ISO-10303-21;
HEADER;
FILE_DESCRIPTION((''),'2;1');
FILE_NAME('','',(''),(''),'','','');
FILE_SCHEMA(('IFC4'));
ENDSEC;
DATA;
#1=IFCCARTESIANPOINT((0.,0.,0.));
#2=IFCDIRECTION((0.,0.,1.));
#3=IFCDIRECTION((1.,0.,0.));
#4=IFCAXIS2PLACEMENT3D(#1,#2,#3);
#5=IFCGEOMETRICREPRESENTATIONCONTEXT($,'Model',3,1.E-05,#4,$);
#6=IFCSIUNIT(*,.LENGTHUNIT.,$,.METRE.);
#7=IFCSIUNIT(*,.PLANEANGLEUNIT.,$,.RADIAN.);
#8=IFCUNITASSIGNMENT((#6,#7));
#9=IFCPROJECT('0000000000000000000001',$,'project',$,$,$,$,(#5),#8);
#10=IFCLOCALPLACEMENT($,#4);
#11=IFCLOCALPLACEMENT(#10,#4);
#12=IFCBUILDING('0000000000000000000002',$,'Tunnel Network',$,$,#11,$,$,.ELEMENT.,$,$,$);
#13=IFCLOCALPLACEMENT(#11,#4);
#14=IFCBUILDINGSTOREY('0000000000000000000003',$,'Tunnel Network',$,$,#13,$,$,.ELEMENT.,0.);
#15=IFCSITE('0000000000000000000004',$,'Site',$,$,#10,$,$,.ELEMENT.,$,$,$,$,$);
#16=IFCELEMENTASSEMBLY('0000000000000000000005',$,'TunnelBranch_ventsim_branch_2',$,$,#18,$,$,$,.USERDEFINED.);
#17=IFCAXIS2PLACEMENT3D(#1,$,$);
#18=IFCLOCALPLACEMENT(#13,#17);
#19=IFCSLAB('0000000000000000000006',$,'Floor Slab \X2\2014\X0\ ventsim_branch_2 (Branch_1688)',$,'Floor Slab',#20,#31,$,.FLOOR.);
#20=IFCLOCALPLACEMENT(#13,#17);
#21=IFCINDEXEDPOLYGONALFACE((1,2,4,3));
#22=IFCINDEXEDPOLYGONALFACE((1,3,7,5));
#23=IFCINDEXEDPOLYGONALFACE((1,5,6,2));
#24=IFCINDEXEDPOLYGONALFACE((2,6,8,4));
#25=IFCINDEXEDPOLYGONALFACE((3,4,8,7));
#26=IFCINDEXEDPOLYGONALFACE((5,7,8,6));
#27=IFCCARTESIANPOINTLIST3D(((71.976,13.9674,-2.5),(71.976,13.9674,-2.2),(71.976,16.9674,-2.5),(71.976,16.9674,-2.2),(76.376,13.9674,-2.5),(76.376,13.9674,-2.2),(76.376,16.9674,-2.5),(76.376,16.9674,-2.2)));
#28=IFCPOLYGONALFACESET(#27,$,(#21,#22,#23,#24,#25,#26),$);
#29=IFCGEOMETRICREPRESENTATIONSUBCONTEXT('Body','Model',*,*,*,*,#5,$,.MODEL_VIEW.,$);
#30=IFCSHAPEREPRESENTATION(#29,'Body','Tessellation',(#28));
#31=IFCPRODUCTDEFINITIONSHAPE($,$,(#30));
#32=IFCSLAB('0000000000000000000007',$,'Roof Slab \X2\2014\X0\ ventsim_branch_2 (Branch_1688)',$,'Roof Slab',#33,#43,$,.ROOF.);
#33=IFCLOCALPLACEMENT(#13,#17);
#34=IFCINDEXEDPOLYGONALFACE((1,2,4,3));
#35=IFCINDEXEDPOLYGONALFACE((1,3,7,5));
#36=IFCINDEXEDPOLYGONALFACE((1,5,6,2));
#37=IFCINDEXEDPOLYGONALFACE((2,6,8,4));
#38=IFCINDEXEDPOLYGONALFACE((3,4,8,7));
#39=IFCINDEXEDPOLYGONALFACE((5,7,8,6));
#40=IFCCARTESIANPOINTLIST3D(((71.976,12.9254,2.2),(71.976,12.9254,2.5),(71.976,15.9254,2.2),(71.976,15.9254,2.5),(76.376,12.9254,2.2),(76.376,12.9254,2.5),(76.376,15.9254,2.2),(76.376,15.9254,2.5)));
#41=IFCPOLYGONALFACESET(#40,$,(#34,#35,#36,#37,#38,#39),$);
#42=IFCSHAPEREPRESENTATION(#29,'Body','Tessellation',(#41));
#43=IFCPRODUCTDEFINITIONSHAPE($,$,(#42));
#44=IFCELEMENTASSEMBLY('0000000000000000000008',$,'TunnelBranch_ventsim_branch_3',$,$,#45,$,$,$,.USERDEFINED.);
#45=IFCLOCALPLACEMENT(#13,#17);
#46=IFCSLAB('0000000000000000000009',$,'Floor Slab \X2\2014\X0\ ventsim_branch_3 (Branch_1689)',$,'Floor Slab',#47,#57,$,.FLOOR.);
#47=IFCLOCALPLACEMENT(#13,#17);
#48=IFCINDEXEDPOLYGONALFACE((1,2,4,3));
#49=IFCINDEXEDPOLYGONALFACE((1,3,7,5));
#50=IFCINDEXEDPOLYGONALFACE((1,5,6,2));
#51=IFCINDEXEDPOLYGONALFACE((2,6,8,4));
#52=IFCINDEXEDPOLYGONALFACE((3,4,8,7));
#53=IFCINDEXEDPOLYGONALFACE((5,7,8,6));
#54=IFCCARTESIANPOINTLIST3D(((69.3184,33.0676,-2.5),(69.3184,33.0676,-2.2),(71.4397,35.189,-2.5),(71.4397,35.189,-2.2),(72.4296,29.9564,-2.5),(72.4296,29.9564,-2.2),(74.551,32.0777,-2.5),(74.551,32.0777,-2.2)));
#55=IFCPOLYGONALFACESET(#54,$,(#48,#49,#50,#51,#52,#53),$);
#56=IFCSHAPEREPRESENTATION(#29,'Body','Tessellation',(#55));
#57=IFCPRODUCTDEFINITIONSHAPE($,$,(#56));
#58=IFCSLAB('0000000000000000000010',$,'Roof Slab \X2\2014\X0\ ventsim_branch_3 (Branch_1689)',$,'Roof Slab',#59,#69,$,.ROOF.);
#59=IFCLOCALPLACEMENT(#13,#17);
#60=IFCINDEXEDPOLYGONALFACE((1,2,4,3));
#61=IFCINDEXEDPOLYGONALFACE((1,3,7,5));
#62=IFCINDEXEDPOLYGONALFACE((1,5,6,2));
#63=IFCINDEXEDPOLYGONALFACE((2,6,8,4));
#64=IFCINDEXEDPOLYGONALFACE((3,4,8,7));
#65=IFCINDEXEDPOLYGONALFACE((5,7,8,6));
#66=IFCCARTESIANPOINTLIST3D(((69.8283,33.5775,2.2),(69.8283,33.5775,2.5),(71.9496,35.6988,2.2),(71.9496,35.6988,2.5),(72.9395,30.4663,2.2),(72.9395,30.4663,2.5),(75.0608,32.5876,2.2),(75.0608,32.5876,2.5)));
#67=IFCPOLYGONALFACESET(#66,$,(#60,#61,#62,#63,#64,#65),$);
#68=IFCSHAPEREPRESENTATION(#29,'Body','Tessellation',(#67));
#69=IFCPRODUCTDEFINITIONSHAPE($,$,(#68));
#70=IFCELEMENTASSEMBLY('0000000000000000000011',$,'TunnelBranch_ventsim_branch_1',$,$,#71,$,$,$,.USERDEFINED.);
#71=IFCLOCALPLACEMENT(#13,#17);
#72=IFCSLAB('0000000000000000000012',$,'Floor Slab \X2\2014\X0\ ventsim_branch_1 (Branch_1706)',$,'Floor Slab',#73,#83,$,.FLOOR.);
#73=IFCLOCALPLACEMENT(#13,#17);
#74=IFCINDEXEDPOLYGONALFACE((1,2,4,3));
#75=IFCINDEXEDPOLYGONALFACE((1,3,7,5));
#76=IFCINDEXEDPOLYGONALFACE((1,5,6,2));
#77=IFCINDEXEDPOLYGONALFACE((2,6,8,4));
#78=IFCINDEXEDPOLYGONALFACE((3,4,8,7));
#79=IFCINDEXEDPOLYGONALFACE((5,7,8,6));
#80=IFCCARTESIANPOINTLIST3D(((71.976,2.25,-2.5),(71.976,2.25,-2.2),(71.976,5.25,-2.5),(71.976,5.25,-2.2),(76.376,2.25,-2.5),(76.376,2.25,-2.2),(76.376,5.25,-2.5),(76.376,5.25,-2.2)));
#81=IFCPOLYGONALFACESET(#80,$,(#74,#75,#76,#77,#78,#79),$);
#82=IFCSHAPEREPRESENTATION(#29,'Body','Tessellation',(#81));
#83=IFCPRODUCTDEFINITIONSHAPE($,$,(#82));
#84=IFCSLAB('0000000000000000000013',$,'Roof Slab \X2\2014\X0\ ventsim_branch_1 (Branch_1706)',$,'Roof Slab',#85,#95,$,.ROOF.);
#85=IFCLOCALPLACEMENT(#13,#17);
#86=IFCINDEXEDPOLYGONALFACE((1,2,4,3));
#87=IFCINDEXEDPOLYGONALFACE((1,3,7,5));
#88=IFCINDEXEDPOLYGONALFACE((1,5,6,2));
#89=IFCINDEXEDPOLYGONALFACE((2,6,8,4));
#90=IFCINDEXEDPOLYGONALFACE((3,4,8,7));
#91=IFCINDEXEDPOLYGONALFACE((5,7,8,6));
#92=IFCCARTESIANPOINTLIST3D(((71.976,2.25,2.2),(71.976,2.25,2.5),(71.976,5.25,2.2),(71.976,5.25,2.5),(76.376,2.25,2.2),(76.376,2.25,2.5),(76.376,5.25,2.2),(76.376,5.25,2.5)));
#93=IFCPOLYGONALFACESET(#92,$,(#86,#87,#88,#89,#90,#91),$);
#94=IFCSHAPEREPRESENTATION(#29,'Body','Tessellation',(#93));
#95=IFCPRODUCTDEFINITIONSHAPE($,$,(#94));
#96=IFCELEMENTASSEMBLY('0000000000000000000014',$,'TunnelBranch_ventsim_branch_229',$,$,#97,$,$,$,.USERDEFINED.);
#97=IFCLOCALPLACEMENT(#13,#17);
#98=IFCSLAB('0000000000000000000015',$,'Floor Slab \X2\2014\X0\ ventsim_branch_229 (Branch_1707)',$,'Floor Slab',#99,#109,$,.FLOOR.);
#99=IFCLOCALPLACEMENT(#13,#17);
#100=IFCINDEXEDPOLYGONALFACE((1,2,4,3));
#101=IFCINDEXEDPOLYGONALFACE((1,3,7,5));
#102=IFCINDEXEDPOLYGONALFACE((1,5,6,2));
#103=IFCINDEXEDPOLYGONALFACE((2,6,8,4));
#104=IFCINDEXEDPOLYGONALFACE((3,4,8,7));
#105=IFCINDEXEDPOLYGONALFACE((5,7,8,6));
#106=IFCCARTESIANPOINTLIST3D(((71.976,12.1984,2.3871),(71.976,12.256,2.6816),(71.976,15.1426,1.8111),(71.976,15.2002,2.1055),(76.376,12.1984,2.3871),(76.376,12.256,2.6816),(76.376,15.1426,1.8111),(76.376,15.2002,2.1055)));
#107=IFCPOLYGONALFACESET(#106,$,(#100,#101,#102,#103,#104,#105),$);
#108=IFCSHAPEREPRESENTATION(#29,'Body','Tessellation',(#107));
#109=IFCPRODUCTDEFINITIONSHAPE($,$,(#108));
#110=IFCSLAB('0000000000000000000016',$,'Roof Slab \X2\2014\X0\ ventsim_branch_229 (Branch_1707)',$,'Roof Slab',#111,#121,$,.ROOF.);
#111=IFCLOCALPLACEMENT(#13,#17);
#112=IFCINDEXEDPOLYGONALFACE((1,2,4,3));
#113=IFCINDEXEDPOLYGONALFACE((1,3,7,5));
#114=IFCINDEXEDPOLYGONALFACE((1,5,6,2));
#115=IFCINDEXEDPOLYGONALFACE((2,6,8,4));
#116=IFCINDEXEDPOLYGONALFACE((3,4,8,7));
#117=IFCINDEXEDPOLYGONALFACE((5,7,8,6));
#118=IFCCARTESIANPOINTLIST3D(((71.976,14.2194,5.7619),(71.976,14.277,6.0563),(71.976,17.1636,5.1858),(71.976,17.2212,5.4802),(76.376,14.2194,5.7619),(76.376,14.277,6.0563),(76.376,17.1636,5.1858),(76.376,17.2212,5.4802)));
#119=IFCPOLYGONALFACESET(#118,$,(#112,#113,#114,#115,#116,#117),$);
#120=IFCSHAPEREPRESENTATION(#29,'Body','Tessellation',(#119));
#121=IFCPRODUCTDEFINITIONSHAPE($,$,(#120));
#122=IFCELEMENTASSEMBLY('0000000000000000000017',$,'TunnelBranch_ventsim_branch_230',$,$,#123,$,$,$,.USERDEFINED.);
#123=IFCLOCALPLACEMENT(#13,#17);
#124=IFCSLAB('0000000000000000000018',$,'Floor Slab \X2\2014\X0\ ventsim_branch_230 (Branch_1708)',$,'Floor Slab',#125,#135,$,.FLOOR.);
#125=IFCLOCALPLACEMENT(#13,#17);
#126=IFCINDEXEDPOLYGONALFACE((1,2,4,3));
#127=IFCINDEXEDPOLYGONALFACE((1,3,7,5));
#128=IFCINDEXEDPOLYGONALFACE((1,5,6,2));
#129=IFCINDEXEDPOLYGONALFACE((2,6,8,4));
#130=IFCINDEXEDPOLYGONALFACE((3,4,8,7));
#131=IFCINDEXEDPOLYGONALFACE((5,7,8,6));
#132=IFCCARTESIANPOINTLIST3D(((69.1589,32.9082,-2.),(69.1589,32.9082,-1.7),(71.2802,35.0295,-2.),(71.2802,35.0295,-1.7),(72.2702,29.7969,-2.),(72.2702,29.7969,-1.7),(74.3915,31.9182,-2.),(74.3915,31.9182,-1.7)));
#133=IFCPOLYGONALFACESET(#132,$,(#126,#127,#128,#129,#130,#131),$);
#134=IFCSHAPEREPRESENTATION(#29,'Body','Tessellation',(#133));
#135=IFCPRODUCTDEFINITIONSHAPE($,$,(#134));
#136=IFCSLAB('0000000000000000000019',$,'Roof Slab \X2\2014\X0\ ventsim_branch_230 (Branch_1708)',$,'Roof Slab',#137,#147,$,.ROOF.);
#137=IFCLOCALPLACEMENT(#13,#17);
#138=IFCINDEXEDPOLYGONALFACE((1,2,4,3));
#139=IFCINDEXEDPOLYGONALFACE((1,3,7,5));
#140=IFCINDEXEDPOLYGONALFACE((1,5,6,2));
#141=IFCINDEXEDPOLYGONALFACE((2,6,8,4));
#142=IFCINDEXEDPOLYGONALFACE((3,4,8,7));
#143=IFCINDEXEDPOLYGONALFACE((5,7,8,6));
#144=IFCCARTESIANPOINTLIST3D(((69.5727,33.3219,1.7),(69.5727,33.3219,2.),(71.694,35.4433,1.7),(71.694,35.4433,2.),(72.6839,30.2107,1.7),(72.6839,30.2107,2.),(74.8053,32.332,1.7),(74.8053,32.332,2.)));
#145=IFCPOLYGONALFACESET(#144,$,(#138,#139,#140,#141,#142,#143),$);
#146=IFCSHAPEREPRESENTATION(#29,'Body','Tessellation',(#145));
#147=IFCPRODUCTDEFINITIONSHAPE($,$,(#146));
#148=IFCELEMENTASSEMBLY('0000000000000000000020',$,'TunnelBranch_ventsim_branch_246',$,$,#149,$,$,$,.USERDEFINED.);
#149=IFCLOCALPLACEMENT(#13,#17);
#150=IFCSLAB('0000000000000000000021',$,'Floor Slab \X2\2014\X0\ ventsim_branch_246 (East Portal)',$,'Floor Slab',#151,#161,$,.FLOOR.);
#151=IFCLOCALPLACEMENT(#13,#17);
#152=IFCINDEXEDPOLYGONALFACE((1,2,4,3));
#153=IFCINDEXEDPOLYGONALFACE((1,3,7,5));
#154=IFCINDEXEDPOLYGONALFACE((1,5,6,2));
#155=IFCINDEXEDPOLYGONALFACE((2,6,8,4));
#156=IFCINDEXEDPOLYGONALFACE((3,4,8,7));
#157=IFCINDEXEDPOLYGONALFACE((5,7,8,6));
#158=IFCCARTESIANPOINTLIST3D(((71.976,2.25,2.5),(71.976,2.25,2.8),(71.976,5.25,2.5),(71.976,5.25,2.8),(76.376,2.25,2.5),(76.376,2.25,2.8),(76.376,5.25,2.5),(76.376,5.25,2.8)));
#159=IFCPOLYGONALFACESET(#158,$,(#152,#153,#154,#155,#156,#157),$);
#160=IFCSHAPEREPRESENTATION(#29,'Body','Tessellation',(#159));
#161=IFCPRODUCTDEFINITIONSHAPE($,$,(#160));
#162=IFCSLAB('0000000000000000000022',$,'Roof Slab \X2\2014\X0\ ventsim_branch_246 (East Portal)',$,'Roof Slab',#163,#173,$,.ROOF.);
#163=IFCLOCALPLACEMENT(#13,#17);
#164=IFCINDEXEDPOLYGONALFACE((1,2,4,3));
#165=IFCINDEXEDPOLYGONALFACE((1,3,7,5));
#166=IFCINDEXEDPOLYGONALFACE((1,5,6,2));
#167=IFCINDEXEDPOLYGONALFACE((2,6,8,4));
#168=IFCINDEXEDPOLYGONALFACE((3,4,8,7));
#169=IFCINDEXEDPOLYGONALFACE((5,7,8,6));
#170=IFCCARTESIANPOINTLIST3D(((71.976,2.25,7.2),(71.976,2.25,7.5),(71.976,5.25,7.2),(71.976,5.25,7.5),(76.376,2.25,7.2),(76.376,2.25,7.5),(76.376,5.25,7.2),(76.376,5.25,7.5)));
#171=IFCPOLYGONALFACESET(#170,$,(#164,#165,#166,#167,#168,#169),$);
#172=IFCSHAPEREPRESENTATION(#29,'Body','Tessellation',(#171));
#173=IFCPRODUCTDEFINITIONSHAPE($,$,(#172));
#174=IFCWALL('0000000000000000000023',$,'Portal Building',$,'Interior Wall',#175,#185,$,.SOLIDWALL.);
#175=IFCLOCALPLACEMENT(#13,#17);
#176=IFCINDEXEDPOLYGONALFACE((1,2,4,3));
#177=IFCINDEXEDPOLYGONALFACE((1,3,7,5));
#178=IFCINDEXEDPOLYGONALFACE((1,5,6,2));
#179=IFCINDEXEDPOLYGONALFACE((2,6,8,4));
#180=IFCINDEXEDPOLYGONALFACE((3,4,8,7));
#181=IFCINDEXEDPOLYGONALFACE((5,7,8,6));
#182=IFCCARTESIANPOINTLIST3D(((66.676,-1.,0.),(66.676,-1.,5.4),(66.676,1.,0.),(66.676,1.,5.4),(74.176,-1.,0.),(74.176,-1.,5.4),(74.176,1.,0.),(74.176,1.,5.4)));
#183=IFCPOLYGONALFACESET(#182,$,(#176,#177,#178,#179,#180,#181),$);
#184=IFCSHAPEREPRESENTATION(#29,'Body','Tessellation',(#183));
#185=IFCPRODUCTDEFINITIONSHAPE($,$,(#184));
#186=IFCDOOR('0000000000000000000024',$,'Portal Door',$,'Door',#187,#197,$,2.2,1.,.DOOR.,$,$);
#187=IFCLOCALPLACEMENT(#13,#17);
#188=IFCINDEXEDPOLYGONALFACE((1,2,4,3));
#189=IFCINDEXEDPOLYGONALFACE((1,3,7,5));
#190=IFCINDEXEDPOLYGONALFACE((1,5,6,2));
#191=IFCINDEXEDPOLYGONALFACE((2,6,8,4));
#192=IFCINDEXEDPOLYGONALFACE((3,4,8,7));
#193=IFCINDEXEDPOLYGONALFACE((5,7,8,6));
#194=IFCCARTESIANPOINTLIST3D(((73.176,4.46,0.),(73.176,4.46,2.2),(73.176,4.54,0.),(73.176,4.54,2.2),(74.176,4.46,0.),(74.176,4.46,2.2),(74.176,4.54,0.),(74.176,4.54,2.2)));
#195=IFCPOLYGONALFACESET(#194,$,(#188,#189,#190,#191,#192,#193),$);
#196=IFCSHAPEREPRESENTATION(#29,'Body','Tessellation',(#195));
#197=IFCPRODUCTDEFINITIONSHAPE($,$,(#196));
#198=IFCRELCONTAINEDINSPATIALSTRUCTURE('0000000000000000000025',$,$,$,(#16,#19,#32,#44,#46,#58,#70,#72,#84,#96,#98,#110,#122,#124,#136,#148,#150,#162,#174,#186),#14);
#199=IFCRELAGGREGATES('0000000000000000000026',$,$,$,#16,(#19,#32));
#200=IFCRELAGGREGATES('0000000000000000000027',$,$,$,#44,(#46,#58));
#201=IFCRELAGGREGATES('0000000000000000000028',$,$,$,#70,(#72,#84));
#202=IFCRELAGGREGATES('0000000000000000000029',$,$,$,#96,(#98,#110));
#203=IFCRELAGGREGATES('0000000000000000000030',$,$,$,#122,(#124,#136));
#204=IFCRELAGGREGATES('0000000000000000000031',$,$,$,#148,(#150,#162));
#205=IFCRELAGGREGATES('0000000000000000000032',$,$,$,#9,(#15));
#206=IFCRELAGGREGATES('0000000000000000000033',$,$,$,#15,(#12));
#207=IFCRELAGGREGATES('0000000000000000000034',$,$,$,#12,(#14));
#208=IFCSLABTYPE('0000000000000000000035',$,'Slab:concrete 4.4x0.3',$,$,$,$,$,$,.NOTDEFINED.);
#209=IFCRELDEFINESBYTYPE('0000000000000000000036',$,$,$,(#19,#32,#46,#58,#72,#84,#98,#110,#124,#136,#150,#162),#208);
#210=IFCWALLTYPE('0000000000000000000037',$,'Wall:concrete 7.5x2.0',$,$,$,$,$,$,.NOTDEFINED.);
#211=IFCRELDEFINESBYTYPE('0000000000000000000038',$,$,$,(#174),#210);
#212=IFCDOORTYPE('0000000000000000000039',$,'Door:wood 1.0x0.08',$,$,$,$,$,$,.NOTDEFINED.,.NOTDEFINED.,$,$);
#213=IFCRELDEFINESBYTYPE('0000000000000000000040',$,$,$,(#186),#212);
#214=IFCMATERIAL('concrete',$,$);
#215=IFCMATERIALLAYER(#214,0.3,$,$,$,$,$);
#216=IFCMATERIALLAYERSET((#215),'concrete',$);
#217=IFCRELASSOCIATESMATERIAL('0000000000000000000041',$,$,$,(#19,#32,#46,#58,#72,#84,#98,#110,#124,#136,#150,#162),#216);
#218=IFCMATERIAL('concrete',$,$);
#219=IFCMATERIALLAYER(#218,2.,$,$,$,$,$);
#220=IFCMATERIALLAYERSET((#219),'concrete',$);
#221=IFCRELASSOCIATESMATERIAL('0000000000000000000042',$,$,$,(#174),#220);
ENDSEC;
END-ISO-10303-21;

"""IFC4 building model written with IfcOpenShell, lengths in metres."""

from ifc_helpers import new_model, si_unit, frame, origin_with_axes, origin_2d_with_axis, place, context, subcontext, project, spatial, rectangle, extrude, material, layer, layer_set, layer_usage, type_object, element, aggregate, save


model = new_model("IFC4")

# Units and contexts
model_context = context("Model", 3, precision=1e-05, world=origin_with_axes())
body_context = subcontext(model_context, "Body", "Model", "MODEL_VIEW")
ifc_project = project(units=[si_unit("LENGTHUNIT", "METRE"), si_unit("PLANEANGLEUNIT", "RADIAN")], contexts=[model_context])

# Site, building, storey
site_placement = place(None, origin_with_axes())
site = spatial("IfcSite", under=ifc_project, at=site_placement, Name="Site", CompositionType="ELEMENT")
building_placement = place(site_placement, origin_with_axes())
building = spatial("IfcBuilding", under=site, at=building_placement, Name="Tunnel Network", CompositionType="ELEMENT")
storey_placement = place(building_placement, origin_with_axes())
storey = spatial("IfcBuildingStorey", under=building, at=storey_placement, Name="Tunnel Network", CompositionType="ELEMENT", Elevation=0.0)

# Element assemblies, slabs
assembly_1_placement = place(storey_placement, frame((71.826, 11.0879, 0.0), z_axis=(0.0, 1.0, 0.0), x_axis=(1.0, 0.0, 0.0)))
assembly_1 = element("IfcElementAssembly", 1, at=assembly_1_placement, inside=storey, Name="TunnelBranch_ventsim_branch_2", PredefinedType="USERDEFINED")
ifc_material_1 = material(Name="concrete")
ifc_layer_1 = layer(ifc_material_1, 0.3)
ifc_layer_set_1 = layer_set([ifc_layer_1], Name="concrete")
ifc_layer_usage_1 = layer_usage(ifc_layer_set_1, "AXIS3", "POSITIVE", 0.0)
slab_type = type_object("IfcSlabType", Name="Slab:concrete 4.4x0.3")
slab_1_placement = place(storey_placement, frame((74.176, 13.9674, -2.35), z_axis=(0.0, 1.0, 0.0), x_axis=(1.0, 0.0, 0.0)))
slab_1 = element("IfcSlab", 2, at=slab_1_placement, inside=storey, type_object=slab_type, material=ifc_layer_usage_1, Name="Floor Slab — ventsim_branch_2 (Branch_1688)", ObjectType="Floor Slab", PredefinedType="FLOOR", context=body_context, shape_type="SweptSolid", body=[
    extrude(rectangle(XDim=4.4, YDim=0.3, at=origin_2d_with_axis()), origin_with_axes(), (0.0, 0.0, 1.0), 3.0),
])
ifc_layer_usage_2 = layer_usage(ifc_layer_set_1, "AXIS3", "POSITIVE", 0.0)
slab_2_placement = place(storey_placement, frame((74.176, 12.9254, 2.35), z_axis=(0.0, 1.0, 0.0), x_axis=(1.0, 0.0, 0.0)))
slab_2 = element("IfcSlab", 3, at=slab_2_placement, inside=storey, type_object=slab_type, material=ifc_layer_usage_2, Name="Roof Slab — ventsim_branch_2 (Branch_1688)", ObjectType="Roof Slab", PredefinedType="ROOF", context=body_context, shape_type="SweptSolid", body=[
    extrude(rectangle(XDim=4.4, YDim=0.3, at=origin_2d_with_axis()), origin_with_axes(), (0.0, 0.0, 1.0), 3.0),
])
assembly_2_placement = place(storey_placement, frame((68.165, 32.1264, 0.0), z_axis=(0.707107, 0.707107, 0.0), x_axis=(0.707107, -0.707107, 0.0)))
assembly_2 = element("IfcElementAssembly", 4, at=assembly_2_placement, inside=storey, Name="TunnelBranch_ventsim_branch_3", PredefinedType="USERDEFINED")
ifc_layer_usage_3 = layer_usage(ifc_layer_set_1, "AXIS3", "POSITIVE", 0.0)
slab_3_placement = place(storey_placement, frame((70.874, 31.512, -2.35), z_axis=(0.707107, 0.707107, 0.0), x_axis=(0.707107, -0.707107, 0.0)))
slab_3 = element("IfcSlab", 5, at=slab_3_placement, inside=storey, type_object=slab_type, material=ifc_layer_usage_3, Name="Floor Slab — ventsim_branch_3 (Branch_1689)", ObjectType="Floor Slab", PredefinedType="FLOOR", context=body_context, shape_type="SweptSolid", body=[
    extrude(rectangle(XDim=4.4, YDim=0.3, at=origin_2d_with_axis()), origin_with_axes(), (0.0, 0.0, 1.0), 3.0),
])
ifc_layer_usage_4 = layer_usage(ifc_layer_set_1, "AXIS3", "POSITIVE", 0.0)
slab_4_placement = place(storey_placement, frame((71.3839, 32.0219, 2.35), z_axis=(0.707107, 0.707107, 0.0), x_axis=(0.707107, -0.707107, 0.0)))
slab_4 = element("IfcSlab", 6, at=slab_4_placement, inside=storey, type_object=slab_type, material=ifc_layer_usage_4, Name="Roof Slab — ventsim_branch_3 (Branch_1689)", ObjectType="Roof Slab", PredefinedType="ROOF", context=body_context, shape_type="SweptSolid", body=[
    extrude(rectangle(XDim=4.4, YDim=0.3, at=origin_2d_with_axis()), origin_with_axes(), (0.0, 0.0, 1.0), 3.0),
])
assembly_3_placement = place(storey_placement, frame((71.826, 2.25, 0.0), z_axis=(0.0, 1.0, 0.0), x_axis=(1.0, 0.0, 0.0)))
assembly_3 = element("IfcElementAssembly", 7, at=assembly_3_placement, inside=storey, Name="TunnelBranch_ventsim_branch_1", PredefinedType="USERDEFINED")
ifc_layer_usage_5 = layer_usage(ifc_layer_set_1, "AXIS3", "POSITIVE", 0.0)
slab_5_placement = place(storey_placement, frame((74.176, 2.25, -2.35), z_axis=(0.0, 1.0, 0.0), x_axis=(1.0, 0.0, 0.0)))
slab_5 = element("IfcSlab", 8, at=slab_5_placement, inside=storey, type_object=slab_type, material=ifc_layer_usage_5, Name="Floor Slab — ventsim_branch_1 (Branch_1706)", ObjectType="Floor Slab", PredefinedType="FLOOR", context=body_context, shape_type="SweptSolid", body=[
    extrude(rectangle(XDim=4.4, YDim=0.3, at=origin_2d_with_axis()), origin_with_axes(), (0.0, 0.0, 1.0), 3.0),
])
ifc_layer_usage_6 = layer_usage(ifc_layer_set_1, "AXIS3", "POSITIVE", 0.0)
slab_6_placement = place(storey_placement, frame((74.176, 2.25, 2.35), z_axis=(0.0, 1.0, 0.0), x_axis=(1.0, 0.0, 0.0)))
slab_6 = element("IfcSlab", 9, at=slab_6_placement, inside=storey, type_object=slab_type, material=ifc_layer_usage_6, Name="Roof Slab — ventsim_branch_1 (Branch_1706)", ObjectType="Roof Slab", PredefinedType="ROOF", context=body_context, shape_type="SweptSolid", body=[
    extrude(rectangle(XDim=4.4, YDim=0.3, at=origin_2d_with_axis()), origin_with_axes(), (0.0, 0.0, 1.0), 3.0),
])
assembly_4_placement = place(storey_placement, frame((71.826, 11.4852, 4.5646), z_axis=(0.0, 0.98139, -0.192023), x_axis=(1.0, 0.0, 0.0)))
assembly_4 = element("IfcElementAssembly", 10, at=assembly_4_placement, inside=storey, Name="TunnelBranch_ventsim_branch_229", PredefinedType="USERDEFINED")
ifc_layer_usage_7 = layer_usage(ifc_layer_set_1, "AXIS3", "POSITIVE", 0.0)
slab_7_placement = place(storey_placement, frame((74.176, 12.2272, 2.5343), z_axis=(0.0, 0.98139, -0.192023), x_axis=(1.0, 0.0, 0.0)))
slab_7 = element("IfcSlab", 11, at=slab_7_placement, inside=storey, type_object=slab_type, material=ifc_layer_usage_7, Name="Floor Slab — ventsim_branch_229 (Branch_1707)", ObjectType="Floor Slab", PredefinedType="FLOOR", context=body_context, shape_type="SweptSolid", body=[
    extrude(rectangle(XDim=4.4, YDim=0.3, at=origin_2d_with_axis()), origin_with_axes(), (0.0, 0.0, 1.0), 3.0),
])
ifc_layer_usage_8 = layer_usage(ifc_layer_set_1, "AXIS3", "POSITIVE", 0.0)
slab_8_placement = place(storey_placement, frame((74.176, 14.2482, 5.9091), z_axis=(0.0, 0.98139, -0.192023), x_axis=(1.0, 0.0, 0.0)))
slab_8 = element("IfcSlab", 12, at=slab_8_placement, inside=storey, type_object=slab_type, material=ifc_layer_usage_8, Name="Roof Slab — ventsim_branch_229 (Branch_1707)", ObjectType="Roof Slab", PredefinedType="ROOF", context=body_context, shape_type="SweptSolid", body=[
    extrude(rectangle(XDim=4.4, YDim=0.3, at=origin_2d_with_axis()), origin_with_axes(), (0.0, 0.0, 1.0), 3.0),
])
assembly_5_placement = place(storey_placement, frame((68.165, 32.1264, 0.0), z_axis=(0.707107, 0.707107, 0.0), x_axis=(0.707107, -0.707107, 0.0)))
assembly_5 = element("IfcElementAssembly", 13, at=assembly_5_placement, inside=storey, Name="TunnelBranch_ventsim_branch_230", PredefinedType="USERDEFINED")
ifc_layer_usage_9 = layer_usage(ifc_layer_set_1, "AXIS3", "POSITIVE", 0.0)
slab_9_placement = place(storey_placement, frame((70.7145, 31.3525, -1.85), z_axis=(0.707107, 0.707107, 0.0), x_axis=(0.707107, -0.707107, 0.0)))
slab_9 = element("IfcSlab", 14, at=slab_9_placement, inside=storey, type_object=slab_type, material=ifc_layer_usage_9, Name="Floor Slab — ventsim_branch_230 (Branch_1708)", ObjectType="Floor Slab", PredefinedType="FLOOR", context=body_context, shape_type="SweptSolid", body=[
    extrude(rectangle(XDim=4.4, YDim=0.3, at=origin_2d_with_axis()), origin_with_axes(), (0.0, 0.0, 1.0), 3.0),
])
ifc_layer_usage_10 = layer_usage(ifc_layer_set_1, "AXIS3", "POSITIVE", 0.0)
slab_10_placement = place(storey_placement, frame((71.1283, 31.7663, 1.85), z_axis=(0.707107, 0.707107, 0.0), x_axis=(0.707107, -0.707107, 0.0)))
slab_10 = element("IfcSlab", 15, at=slab_10_placement, inside=storey, type_object=slab_type, material=ifc_layer_usage_10, Name="Roof Slab — ventsim_branch_230 (Branch_1708)", ObjectType="Roof Slab", PredefinedType="ROOF", context=body_context, shape_type="SweptSolid", body=[
    extrude(rectangle(XDim=4.4, YDim=0.3, at=origin_2d_with_axis()), origin_with_axes(), (0.0, 0.0, 1.0), 3.0),
])
assembly_6_placement = place(storey_placement, frame((71.826, 2.25, 5.0), z_axis=(0.0, 1.0, 0.0), x_axis=(1.0, 0.0, 0.0)))
assembly_6 = element("IfcElementAssembly", 16, at=assembly_6_placement, inside=storey, Name="TunnelBranch_ventsim_branch_246", PredefinedType="USERDEFINED")
ifc_layer_usage_11 = layer_usage(ifc_layer_set_1, "AXIS3", "POSITIVE", 0.0)
slab_11_placement = place(storey_placement, frame((74.176, 2.25, 2.65), z_axis=(0.0, 1.0, 0.0), x_axis=(1.0, 0.0, 0.0)))
slab_11 = element("IfcSlab", 17, at=slab_11_placement, inside=storey, type_object=slab_type, material=ifc_layer_usage_11, Name="Floor Slab — ventsim_branch_246 (East Portal)", ObjectType="Floor Slab", PredefinedType="FLOOR", context=body_context, shape_type="SweptSolid", body=[
    extrude(rectangle(XDim=4.4, YDim=0.3, at=origin_2d_with_axis()), origin_with_axes(), (0.0, 0.0, 1.0), 3.0),
])
ifc_layer_usage_12 = layer_usage(ifc_layer_set_1, "AXIS3", "POSITIVE", 0.0)
slab_12_placement = place(storey_placement, frame((74.176, 2.25, 7.35), z_axis=(0.0, 1.0, 0.0), x_axis=(1.0, 0.0, 0.0)))
slab_12 = element("IfcSlab", 18, at=slab_12_placement, inside=storey, type_object=slab_type, material=ifc_layer_usage_12, Name="Roof Slab — ventsim_branch_246 (East Portal)", ObjectType="Roof Slab", PredefinedType="ROOF", context=body_context, shape_type="SweptSolid", body=[
    extrude(rectangle(XDim=4.4, YDim=0.3, at=origin_2d_with_axis()), origin_with_axes(), (0.0, 0.0, 1.0), 3.0),
])

# Wall
ifc_material_2 = material(Name="concrete")
ifc_layer_2 = layer(ifc_material_2, 2.0)
ifc_layer_set_2 = layer_set([ifc_layer_2], Name="concrete")
ifc_layer_usage_13 = layer_usage(ifc_layer_set_2, "AXIS2", "POSITIVE", 0.0)
wall_type_1 = type_object("IfcWallType", Name="Wall:concrete 7.5x2.0")
wall_1_placement = place(storey_placement, frame((70.426, 0.0, 0.0), z_axis=(0.0, 0.0, 1.0), x_axis=(1.0, 0.0, 0.0)))
element("IfcWall", 19, at=wall_1_placement, inside=storey, type_object=wall_type_1, material=ifc_layer_usage_13, Name="Portal Building", ObjectType="Interior Wall", PredefinedType="SOLIDWALL", context=body_context, shape_type="SweptSolid", body=[
    extrude(rectangle(XDim=7.5, YDim=2.0, at=origin_2d_with_axis()), origin_with_axes(), (0.0, 0.0, 1.0), 5.4),
])

# Door
door_type = type_object("IfcDoorType", Name="Door:wood 1.0x0.08")
door_placement = place(storey_placement, frame((73.676, 4.5, 0.0), z_axis=(0.0, 0.0, 1.0), x_axis=(1.0, 0.0, 0.0)))
element("IfcDoor", 20, at=door_placement, inside=storey, type_object=door_type, Name="Portal Door", ObjectType="Door", OverallHeight=2.2, OverallWidth=1.0, PredefinedType="DOOR", context=body_context, shape_type="SweptSolid", body=[
    extrude(rectangle(XDim=1.0, YDim=0.08, at=origin_2d_with_axis()), origin_with_axes(), (0.0, 0.0, 1.0), 2.2),
])

aggregate(assembly_1, [slab_1, slab_2])
aggregate(assembly_2, [slab_3, slab_4])
aggregate(assembly_3, [slab_5, slab_6])
aggregate(assembly_4, [slab_7, slab_8])
aggregate(assembly_5, [slab_9, slab_10])
aggregate(assembly_6, [slab_11, slab_12])

save(model, "model.ifc")
